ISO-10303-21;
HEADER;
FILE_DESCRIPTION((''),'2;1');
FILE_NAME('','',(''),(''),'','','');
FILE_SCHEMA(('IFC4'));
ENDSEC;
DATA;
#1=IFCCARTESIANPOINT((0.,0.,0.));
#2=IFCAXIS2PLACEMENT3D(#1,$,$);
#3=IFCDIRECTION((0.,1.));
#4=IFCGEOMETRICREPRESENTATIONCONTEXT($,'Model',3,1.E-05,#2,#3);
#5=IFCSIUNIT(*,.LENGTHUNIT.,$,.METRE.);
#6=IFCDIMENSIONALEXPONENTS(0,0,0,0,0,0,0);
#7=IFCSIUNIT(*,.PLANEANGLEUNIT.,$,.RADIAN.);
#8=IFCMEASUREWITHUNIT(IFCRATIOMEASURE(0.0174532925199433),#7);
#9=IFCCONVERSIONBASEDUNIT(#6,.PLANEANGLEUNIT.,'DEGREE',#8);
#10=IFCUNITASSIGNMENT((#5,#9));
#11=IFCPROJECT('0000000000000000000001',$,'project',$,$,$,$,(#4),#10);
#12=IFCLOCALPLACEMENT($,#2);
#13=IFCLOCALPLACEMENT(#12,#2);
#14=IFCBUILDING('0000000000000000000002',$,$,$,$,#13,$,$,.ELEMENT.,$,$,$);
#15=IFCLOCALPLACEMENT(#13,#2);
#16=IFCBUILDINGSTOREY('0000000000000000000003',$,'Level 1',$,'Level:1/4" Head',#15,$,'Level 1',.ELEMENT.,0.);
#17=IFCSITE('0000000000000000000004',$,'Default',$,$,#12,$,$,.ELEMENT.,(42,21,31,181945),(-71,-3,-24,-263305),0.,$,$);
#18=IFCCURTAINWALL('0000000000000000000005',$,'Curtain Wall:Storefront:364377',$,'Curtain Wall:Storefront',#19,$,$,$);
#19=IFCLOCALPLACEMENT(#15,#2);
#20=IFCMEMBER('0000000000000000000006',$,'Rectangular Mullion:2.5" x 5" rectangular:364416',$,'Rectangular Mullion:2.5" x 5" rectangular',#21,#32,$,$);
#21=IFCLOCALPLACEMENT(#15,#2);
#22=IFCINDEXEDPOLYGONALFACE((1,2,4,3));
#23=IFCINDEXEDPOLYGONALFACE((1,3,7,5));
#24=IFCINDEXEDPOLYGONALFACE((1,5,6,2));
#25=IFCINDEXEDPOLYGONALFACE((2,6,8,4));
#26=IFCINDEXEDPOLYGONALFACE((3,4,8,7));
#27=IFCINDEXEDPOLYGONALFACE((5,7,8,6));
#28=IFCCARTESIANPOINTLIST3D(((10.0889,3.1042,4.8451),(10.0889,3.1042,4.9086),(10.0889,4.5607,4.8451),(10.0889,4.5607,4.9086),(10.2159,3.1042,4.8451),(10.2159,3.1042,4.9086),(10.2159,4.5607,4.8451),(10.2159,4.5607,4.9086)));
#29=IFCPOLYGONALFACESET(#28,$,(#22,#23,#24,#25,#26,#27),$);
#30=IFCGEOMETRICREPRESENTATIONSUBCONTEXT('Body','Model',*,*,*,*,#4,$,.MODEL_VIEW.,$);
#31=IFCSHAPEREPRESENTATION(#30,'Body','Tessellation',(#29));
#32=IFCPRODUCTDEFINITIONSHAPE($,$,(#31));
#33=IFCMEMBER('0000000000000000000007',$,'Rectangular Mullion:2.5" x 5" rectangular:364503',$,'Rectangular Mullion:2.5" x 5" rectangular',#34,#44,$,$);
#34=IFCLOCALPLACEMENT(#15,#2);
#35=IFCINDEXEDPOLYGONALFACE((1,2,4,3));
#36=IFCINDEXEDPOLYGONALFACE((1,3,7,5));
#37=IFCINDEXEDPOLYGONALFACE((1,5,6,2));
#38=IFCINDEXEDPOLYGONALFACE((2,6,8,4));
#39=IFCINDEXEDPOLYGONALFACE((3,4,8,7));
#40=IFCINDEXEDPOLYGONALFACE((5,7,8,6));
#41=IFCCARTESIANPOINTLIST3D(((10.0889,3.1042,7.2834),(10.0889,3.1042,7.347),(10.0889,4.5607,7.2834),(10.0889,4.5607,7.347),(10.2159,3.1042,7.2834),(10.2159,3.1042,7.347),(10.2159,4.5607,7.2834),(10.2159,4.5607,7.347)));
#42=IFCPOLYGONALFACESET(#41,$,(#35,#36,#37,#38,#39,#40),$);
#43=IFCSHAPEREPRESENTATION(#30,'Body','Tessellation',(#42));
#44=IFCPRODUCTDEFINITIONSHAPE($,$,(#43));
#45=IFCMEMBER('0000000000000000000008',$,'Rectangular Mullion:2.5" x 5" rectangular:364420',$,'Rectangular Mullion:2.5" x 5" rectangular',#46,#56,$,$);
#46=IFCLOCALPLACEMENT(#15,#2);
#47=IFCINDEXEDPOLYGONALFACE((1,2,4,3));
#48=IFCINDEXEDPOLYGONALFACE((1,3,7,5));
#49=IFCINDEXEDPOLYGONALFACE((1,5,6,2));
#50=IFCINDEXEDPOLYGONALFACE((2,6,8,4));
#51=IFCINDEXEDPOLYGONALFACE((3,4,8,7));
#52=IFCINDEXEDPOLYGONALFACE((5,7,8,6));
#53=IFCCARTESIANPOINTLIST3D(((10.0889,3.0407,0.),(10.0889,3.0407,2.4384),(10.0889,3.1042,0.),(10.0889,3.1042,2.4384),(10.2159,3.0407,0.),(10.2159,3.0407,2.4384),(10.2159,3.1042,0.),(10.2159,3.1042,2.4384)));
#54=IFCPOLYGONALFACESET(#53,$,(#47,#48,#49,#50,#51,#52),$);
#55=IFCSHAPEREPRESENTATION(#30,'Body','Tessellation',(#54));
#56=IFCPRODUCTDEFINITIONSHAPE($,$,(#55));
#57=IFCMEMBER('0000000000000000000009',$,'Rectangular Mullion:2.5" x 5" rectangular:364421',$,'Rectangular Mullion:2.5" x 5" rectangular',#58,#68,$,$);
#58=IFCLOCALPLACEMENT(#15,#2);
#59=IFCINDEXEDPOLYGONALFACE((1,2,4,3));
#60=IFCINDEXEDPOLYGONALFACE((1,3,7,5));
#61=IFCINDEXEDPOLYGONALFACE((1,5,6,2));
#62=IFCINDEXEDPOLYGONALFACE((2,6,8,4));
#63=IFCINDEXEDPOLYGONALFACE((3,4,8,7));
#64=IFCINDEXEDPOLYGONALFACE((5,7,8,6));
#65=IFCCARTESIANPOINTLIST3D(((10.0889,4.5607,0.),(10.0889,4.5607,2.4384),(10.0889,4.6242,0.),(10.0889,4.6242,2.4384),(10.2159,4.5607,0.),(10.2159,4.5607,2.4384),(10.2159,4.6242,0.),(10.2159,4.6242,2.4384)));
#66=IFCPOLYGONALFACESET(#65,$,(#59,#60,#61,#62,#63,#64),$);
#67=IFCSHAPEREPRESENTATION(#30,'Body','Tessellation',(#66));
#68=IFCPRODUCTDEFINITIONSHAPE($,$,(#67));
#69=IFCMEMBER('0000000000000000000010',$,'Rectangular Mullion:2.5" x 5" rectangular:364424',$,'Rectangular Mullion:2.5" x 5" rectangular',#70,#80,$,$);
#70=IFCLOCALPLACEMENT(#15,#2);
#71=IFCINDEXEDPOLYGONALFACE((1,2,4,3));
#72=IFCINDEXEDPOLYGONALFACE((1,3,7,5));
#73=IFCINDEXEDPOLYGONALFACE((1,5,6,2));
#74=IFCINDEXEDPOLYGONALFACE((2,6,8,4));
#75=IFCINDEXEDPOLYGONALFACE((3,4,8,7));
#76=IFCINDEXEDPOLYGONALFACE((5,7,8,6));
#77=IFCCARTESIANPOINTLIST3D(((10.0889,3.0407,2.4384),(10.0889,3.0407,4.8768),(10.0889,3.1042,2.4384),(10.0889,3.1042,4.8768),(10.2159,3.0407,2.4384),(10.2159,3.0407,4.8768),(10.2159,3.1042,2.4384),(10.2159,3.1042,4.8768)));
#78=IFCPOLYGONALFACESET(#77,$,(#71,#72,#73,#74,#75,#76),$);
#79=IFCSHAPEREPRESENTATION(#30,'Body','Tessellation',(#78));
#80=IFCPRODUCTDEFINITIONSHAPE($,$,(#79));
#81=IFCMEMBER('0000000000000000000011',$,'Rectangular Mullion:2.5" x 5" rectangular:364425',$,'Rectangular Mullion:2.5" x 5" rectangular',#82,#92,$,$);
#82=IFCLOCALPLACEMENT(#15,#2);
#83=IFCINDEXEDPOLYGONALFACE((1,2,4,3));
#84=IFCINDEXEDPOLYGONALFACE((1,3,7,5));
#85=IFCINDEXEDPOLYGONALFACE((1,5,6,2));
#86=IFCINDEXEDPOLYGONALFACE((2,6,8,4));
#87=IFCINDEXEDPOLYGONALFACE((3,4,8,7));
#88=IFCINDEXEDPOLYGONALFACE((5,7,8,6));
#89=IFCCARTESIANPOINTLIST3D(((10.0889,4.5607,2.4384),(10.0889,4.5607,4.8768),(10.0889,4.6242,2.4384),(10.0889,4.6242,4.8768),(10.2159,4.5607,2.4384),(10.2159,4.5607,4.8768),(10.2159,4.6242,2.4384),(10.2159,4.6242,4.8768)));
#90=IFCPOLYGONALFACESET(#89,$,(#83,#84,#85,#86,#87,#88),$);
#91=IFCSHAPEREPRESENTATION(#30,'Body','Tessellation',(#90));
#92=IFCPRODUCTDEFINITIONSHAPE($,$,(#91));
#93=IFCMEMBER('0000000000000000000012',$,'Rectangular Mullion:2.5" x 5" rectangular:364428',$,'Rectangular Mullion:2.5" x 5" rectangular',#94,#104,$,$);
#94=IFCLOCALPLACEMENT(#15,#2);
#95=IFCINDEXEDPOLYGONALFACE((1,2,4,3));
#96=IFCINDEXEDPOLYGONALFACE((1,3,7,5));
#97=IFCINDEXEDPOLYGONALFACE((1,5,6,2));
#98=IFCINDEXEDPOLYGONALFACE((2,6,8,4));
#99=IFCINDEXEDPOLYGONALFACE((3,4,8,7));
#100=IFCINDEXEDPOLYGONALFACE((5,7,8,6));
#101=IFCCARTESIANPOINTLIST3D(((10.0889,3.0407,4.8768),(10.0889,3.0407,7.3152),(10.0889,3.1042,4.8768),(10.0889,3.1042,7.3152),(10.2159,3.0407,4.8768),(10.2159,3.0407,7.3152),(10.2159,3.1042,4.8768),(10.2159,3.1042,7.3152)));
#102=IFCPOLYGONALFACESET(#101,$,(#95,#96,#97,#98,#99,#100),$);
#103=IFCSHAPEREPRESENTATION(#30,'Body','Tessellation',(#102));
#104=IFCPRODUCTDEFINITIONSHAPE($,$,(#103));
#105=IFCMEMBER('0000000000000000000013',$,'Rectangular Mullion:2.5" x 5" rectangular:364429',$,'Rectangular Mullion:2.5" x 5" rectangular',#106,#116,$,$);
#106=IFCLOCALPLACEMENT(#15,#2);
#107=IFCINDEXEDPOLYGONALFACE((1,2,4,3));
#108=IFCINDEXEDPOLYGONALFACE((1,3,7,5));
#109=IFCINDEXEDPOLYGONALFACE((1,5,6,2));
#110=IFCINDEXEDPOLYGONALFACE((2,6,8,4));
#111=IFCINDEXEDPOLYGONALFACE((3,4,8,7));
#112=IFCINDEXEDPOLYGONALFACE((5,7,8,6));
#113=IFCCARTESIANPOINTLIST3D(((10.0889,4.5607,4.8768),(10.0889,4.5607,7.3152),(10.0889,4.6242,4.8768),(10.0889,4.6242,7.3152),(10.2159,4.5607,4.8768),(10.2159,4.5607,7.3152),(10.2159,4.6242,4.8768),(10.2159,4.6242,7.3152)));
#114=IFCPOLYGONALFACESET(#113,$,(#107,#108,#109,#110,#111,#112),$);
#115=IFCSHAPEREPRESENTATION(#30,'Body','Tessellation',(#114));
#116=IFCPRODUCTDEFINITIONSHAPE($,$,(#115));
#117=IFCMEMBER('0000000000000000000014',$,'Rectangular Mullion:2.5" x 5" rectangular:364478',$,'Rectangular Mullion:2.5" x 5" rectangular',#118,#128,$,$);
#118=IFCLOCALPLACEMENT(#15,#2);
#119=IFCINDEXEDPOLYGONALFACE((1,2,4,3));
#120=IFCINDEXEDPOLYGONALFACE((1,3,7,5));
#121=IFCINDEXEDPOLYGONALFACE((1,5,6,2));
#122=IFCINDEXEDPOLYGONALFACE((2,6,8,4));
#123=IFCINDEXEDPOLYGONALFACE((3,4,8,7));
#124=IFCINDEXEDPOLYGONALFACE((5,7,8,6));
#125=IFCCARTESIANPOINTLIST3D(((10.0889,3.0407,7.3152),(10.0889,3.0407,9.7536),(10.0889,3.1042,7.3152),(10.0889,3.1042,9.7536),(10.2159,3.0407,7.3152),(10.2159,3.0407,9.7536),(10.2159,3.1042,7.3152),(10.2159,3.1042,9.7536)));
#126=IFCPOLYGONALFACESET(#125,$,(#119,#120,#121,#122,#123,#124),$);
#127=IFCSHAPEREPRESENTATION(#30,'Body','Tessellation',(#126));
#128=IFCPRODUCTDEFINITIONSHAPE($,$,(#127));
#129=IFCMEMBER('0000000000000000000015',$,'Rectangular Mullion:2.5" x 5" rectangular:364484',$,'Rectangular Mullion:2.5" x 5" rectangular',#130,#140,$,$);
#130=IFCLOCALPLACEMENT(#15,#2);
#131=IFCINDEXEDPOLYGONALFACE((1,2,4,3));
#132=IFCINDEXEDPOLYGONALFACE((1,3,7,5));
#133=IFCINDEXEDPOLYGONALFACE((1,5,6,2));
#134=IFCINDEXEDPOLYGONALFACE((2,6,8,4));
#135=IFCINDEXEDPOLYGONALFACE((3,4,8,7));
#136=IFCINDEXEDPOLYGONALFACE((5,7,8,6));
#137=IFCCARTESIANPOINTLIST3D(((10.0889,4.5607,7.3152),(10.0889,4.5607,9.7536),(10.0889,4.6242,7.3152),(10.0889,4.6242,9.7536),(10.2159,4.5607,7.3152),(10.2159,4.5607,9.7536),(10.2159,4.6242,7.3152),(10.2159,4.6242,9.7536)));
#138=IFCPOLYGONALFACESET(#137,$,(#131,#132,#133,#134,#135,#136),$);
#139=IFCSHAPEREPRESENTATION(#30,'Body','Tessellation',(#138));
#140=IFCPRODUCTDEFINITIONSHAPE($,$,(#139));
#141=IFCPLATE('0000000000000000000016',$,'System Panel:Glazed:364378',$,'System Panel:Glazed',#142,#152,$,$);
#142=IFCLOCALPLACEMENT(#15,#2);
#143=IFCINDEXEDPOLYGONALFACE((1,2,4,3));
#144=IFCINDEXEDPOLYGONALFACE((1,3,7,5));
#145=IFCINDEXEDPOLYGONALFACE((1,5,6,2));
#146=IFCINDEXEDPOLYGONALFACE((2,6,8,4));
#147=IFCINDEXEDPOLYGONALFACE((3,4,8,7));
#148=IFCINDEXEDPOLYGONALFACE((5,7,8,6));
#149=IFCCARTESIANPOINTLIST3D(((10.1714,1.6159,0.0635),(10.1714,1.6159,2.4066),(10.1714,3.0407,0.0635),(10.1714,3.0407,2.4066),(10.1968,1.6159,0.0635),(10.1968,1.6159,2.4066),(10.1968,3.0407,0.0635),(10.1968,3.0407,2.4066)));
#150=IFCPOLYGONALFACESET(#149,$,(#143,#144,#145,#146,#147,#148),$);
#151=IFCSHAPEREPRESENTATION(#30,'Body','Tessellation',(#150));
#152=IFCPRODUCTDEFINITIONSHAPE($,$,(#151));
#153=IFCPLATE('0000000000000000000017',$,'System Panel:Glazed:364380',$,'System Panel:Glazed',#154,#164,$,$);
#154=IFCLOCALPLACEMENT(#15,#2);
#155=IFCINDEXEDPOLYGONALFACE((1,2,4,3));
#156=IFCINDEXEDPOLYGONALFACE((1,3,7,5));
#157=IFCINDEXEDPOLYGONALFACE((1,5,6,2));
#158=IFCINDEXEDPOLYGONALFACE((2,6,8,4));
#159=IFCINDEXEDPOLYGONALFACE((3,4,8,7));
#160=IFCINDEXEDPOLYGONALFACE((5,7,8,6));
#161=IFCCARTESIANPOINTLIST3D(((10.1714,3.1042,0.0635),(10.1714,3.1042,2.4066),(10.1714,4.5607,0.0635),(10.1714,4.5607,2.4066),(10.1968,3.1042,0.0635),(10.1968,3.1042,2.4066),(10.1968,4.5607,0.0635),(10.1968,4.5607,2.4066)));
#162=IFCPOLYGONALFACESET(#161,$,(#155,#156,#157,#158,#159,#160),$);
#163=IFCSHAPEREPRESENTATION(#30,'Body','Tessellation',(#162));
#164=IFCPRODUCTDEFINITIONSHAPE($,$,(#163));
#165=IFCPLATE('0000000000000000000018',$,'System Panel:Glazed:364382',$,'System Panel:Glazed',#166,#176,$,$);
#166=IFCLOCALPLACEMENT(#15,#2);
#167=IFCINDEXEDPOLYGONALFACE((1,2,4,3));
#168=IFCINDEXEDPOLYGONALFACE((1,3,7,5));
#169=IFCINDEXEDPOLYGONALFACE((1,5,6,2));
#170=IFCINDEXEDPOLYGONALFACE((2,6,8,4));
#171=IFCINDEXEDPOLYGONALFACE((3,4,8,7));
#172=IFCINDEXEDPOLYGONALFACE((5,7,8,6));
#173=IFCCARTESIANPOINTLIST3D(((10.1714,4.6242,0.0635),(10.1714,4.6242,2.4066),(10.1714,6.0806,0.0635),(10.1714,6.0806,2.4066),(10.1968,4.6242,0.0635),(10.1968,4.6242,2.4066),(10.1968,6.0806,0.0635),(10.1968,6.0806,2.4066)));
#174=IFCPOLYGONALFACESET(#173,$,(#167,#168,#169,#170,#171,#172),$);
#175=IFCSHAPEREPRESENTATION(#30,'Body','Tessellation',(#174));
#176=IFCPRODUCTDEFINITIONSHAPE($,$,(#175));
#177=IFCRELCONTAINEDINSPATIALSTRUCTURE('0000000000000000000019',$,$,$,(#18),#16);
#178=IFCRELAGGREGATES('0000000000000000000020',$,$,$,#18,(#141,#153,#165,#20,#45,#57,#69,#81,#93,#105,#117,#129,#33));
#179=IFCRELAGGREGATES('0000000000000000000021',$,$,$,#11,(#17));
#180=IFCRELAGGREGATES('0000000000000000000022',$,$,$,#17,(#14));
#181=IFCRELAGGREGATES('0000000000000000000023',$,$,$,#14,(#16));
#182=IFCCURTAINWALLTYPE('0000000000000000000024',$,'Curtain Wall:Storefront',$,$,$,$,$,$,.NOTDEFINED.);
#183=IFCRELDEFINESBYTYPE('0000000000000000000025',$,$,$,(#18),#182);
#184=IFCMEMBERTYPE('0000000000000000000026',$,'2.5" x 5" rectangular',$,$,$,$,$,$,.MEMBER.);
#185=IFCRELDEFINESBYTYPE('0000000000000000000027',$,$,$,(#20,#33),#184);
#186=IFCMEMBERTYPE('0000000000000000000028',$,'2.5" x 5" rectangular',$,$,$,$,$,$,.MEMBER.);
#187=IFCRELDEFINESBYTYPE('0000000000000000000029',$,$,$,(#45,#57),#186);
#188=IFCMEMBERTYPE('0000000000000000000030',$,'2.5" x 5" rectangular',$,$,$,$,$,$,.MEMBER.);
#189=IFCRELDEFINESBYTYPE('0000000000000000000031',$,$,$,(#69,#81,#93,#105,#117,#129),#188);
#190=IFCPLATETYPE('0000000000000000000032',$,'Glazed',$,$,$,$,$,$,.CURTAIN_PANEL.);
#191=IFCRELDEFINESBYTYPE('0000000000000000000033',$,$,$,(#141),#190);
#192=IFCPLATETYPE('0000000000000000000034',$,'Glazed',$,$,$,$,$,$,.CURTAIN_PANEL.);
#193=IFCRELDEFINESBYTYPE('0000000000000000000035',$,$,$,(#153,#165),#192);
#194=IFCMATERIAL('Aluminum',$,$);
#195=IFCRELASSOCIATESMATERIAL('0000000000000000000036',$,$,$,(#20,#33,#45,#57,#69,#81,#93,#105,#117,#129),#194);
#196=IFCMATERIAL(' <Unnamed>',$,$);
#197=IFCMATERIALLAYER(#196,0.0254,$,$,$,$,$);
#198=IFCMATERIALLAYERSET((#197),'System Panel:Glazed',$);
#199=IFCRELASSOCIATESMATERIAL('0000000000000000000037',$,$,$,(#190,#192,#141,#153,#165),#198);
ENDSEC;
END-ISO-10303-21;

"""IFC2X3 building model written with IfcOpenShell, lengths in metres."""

from ifc_helpers import new_model, entity, si_unit, converted_unit, direction, frame, frame_2d, origin, origin_2d_with_axis, place, context, subcontext, project, spatial, rectangle, extrude, source, transform, mapped, material, layer, layer_set, layer_usage, type_object, type_shapes, element, aggregate, save


model = new_model("IFC2X3")

# Units and contexts
model_context = context("Model", 3, precision=1e-05, world=origin(), true_north=direction((0.0, 1.0)))
body_context = subcontext(model_context, "Body", "Model", "MODEL_VIEW")
ifc_project = project(units=[si_unit("LENGTHUNIT", "METRE"), converted_unit("PLANEANGLEUNIT", "DEGREE", entity("IfcRatioMeasure", 0.0174532925199433), si_unit("PLANEANGLEUNIT", "RADIAN"), dimensions=[0, 0, 0, 0, 0, 0, 0])], contexts=[model_context])

# Site, building, storey
site_placement = place(None, origin())
site = spatial("IfcSite", under=ifc_project, at=site_placement, Name="Default", CompositionType="ELEMENT", RefLatitude=(42, 21, 31, 181945), RefLongitude=(-71, -3, -24, -263305), RefElevation=0.0)
building_placement = place(site_placement, origin())
building = spatial("IfcBuilding", under=site, at=building_placement, CompositionType="ELEMENT")
storey_placement = place(building_placement, origin())
storey = spatial("IfcBuildingStorey", under=building, at=storey_placement, Name="Level 1", ObjectType="Level:1/4\" Head", LongName="Level 1", CompositionType="ELEMENT", Elevation=0.0)

# Shared definitions
curtain_wall_type = type_object("IfcCurtainWallType", Name="Curtain Wall:Storefront", PredefinedType="NOTDEFINED")
ifc_material_1 = material(Name="Aluminum")

# Curtain wall, members, plates
curtain_wall_1_placement = place(storey_placement, origin())
curtain_wall_1 = element("IfcCurtainWall", 1, at=curtain_wall_1_placement, inside=storey, type_object=curtain_wall_type, Name="Curtain Wall:Storefront:364377", ObjectType="Curtain Wall:Storefront")
member_type_1 = type_object("IfcMemberType", Name="2.5\" x 5\" rectangular", PredefinedType="MEMBER")
shared_shape_1 = source(origin(), body_context, "Body", "SweptSolid", [
    extrude(rectangle(XDim=0.127, YDim=0.0635, at=origin_2d_with_axis()), frame((0.0, 0.0, -1.4565), z_axis=(0.0, 0.0, 1.0), x_axis=(0.0, -1.0, 0.0)), (0.0, 0.0, 1.0), 1.4565),
])
type_shapes(member_type_1, [shared_shape_1])
member_1_placement = place(storey_placement, frame((10.1524, 4.5607, 4.8768), z_axis=(0.0, 1.0, 0.0), x_axis=(0.0, 0.0, 1.0)))
member_1 = element("IfcMember", 2, at=member_1_placement, type_object=member_type_1, material=ifc_material_1, Name="Rectangular Mullion:2.5\" x 5\" rectangular:364416", ObjectType="Rectangular Mullion:2.5\" x 5\" rectangular", context=body_context, shape_type="MappedRepresentation", body=[
    mapped(shared_shape_1, transform((0.0, 0.0, 0.0), scale=1.0)),
])
member_2_placement = place(storey_placement, frame((10.1524, 4.5607, 7.3152), z_axis=(0.0, 1.0, 0.0), x_axis=(0.0, 0.0, 1.0)))
member_2 = element("IfcMember", 3, at=member_2_placement, type_object=member_type_1, material=ifc_material_1, Name="Rectangular Mullion:2.5\" x 5\" rectangular:364503", ObjectType="Rectangular Mullion:2.5\" x 5\" rectangular", context=body_context, shape_type="MappedRepresentation", body=[
    mapped(shared_shape_1, transform((0.0, 0.0, 0.0), scale=1.0)),
])
member_type_2 = type_object("IfcMemberType", Name="2.5\" x 5\" rectangular", PredefinedType="MEMBER")
shared_shape_2 = source(origin(), body_context, "Body", "SweptSolid", [
    extrude(rectangle(XDim=0.127, YDim=0.0635, at=origin_2d_with_axis()), frame((0.0, 0.0, -2.4384), z_axis=(0.0, 0.0, 1.0), x_axis=(0.0, -1.0, 0.0)), (0.0, 0.0, 1.0), 2.4384),
])
type_shapes(member_type_2, [shared_shape_2])
member_3_placement = place(storey_placement, frame((10.1524, 3.0724, 0.0), z_axis=(0.0, 0.0, -1.0), x_axis=(0.0, 1.0, 0.0)))
member_3 = element("IfcMember", 4, at=member_3_placement, type_object=member_type_2, material=ifc_material_1, Name="Rectangular Mullion:2.5\" x 5\" rectangular:364420", ObjectType="Rectangular Mullion:2.5\" x 5\" rectangular", context=body_context, shape_type="MappedRepresentation", body=[
    mapped(shared_shape_2, transform((0.0, 0.0, 0.0), scale=1.0)),
])
member_4_placement = place(storey_placement, frame((10.1524, 4.5924, 0.0), z_axis=(0.0, 0.0, -1.0), x_axis=(0.0, 1.0, 0.0)))
member_4 = element("IfcMember", 5, at=member_4_placement, type_object=member_type_2, material=ifc_material_1, Name="Rectangular Mullion:2.5\" x 5\" rectangular:364421", ObjectType="Rectangular Mullion:2.5\" x 5\" rectangular", context=body_context, shape_type="MappedRepresentation", body=[
    mapped(shared_shape_2, transform((0.0, 0.0, 0.0), scale=1.0)),
])
member_type_3 = type_object("IfcMemberType", Name="2.5\" x 5\" rectangular", PredefinedType="MEMBER")
shared_shape_3 = source(origin(), body_context, "Body", "SweptSolid", [
    extrude(rectangle(XDim=0.127, YDim=0.0635, at=origin_2d_with_axis()), frame((0.0, 0.0, -2.4384), z_axis=(0.0, 0.0, 1.0), x_axis=(0.0, -1.0, 0.0)), (0.0, 0.0, 1.0), 2.4384),
])
type_shapes(member_type_3, [shared_shape_3])
member_5_placement = place(storey_placement, frame((10.1524, 3.0724, 2.4384), z_axis=(0.0, 0.0, -1.0), x_axis=(0.0, 1.0, 0.0)))
member_5 = element("IfcMember", 6, at=member_5_placement, type_object=member_type_3, material=ifc_material_1, Name="Rectangular Mullion:2.5\" x 5\" rectangular:364424", ObjectType="Rectangular Mullion:2.5\" x 5\" rectangular", context=body_context, shape_type="MappedRepresentation", body=[
    mapped(shared_shape_3, transform((0.0, 0.0, 0.0), scale=1.0)),
])
member_6_placement = place(storey_placement, frame((10.1524, 4.5924, 2.4384), z_axis=(0.0, 0.0, -1.0), x_axis=(0.0, 1.0, 0.0)))
member_6 = element("IfcMember", 7, at=member_6_placement, type_object=member_type_3, material=ifc_material_1, Name="Rectangular Mullion:2.5\" x 5\" rectangular:364425", ObjectType="Rectangular Mullion:2.5\" x 5\" rectangular", context=body_context, shape_type="MappedRepresentation", body=[
    mapped(shared_shape_3, transform((0.0, 0.0, 0.0), scale=1.0)),
])
member_7_placement = place(storey_placement, frame((10.1524, 3.0724, 4.8768), z_axis=(0.0, 0.0, -1.0), x_axis=(0.0, 1.0, 0.0)))
member_7 = element("IfcMember", 8, at=member_7_placement, type_object=member_type_3, material=ifc_material_1, Name="Rectangular Mullion:2.5\" x 5\" rectangular:364428", ObjectType="Rectangular Mullion:2.5\" x 5\" rectangular", context=body_context, shape_type="MappedRepresentation", body=[
    mapped(shared_shape_3, transform((0.0, 0.0, 0.0), scale=1.0)),
])
member_8_placement = place(storey_placement, frame((10.1524, 4.5924, 4.8768), z_axis=(0.0, 0.0, -1.0), x_axis=(0.0, 1.0, 0.0)))
member_8 = element("IfcMember", 9, at=member_8_placement, type_object=member_type_3, material=ifc_material_1, Name="Rectangular Mullion:2.5\" x 5\" rectangular:364429", ObjectType="Rectangular Mullion:2.5\" x 5\" rectangular", context=body_context, shape_type="MappedRepresentation", body=[
    mapped(shared_shape_3, transform((0.0, 0.0, 0.0), scale=1.0)),
])
member_9_placement = place(storey_placement, frame((10.1524, 3.0724, 7.3152), z_axis=(0.0, 0.0, -1.0), x_axis=(0.0, 1.0, 0.0)))
member_9 = element("IfcMember", 10, at=member_9_placement, type_object=member_type_3, material=ifc_material_1, Name="Rectangular Mullion:2.5\" x 5\" rectangular:364478", ObjectType="Rectangular Mullion:2.5\" x 5\" rectangular", context=body_context, shape_type="MappedRepresentation", body=[
    mapped(shared_shape_3, transform((0.0, 0.0, 0.0), scale=1.0)),
])
member_10_placement = place(storey_placement, frame((10.1524, 4.5924, 7.3152), z_axis=(0.0, 0.0, -1.0), x_axis=(0.0, 1.0, 0.0)))
member_10 = element("IfcMember", 11, at=member_10_placement, type_object=member_type_3, material=ifc_material_1, Name="Rectangular Mullion:2.5\" x 5\" rectangular:364484", ObjectType="Rectangular Mullion:2.5\" x 5\" rectangular", context=body_context, shape_type="MappedRepresentation", body=[
    mapped(shared_shape_3, transform((0.0, 0.0, 0.0), scale=1.0)),
])
ifc_material_2 = material(Name=" <Unnamed>")
ifc_layer_1 = layer(ifc_material_2, 0.0254)
ifc_layer_set_1 = layer_set([ifc_layer_1], Name="System Panel:Glazed")
ifc_layer_usage_1 = layer_usage(ifc_layer_set_1, "AXIS3", "POSITIVE", 0.1042)
plate_type_1 = type_object("IfcPlateType", Name="Glazed", PredefinedType="CURTAIN_PANEL", material=ifc_layer_set_1)
shared_shape_4 = source(origin(), body_context, "Body", "SweptSolid", [
    extrude(rectangle(XDim=0.0254, YDim=1.4248, at=frame_2d((0.0, 0.0), x_axis=(1.0, 0.0))), frame((0.7124, 0.0127, 0.0), z_axis=(0.0, 0.0, 1.0), x_axis=(0.0, 1.0, 0.0)), (0.0, 0.0, 1.0), 2.3432),
])
type_shapes(plate_type_1, [shared_shape_4])
plate_1_placement = place(curtain_wall_1_placement, frame((10.1968, 1.6159, 0.0635), z_axis=(0.0, 0.0, 1.0), x_axis=(0.0, 1.0, 0.0)))
plate_1 = element("IfcPlate", 12, at=plate_1_placement, type_object=plate_type_1, material=ifc_layer_usage_1, Name="System Panel:Glazed:364378", ObjectType="System Panel:Glazed", context=body_context, shape_type="MappedRepresentation", body=[
    mapped(shared_shape_4, transform((0.0, 0.0, 0.0), scale=1.0)),
])
ifc_layer_usage_2 = layer_usage(ifc_layer_set_1, "AXIS3", "POSITIVE", 0.1042)
plate_type_2 = type_object("IfcPlateType", Name="Glazed", PredefinedType="CURTAIN_PANEL", material=ifc_layer_set_1)
shared_shape_5 = source(origin(), body_context, "Body", "SweptSolid", [
    extrude(rectangle(XDim=0.0254, YDim=1.4565, at=origin_2d_with_axis()), frame((0.7282, 0.0127, 0.0), z_axis=(0.0, 0.0, 1.0), x_axis=(0.0, 1.0, 0.0)), (0.0, 0.0, 1.0), 2.3432),
])
type_shapes(plate_type_2, [shared_shape_5])
plate_2_placement = place(curtain_wall_1_placement, frame((10.1968, 3.1042, 0.0635), z_axis=(0.0, 0.0, 1.0), x_axis=(0.0, 1.0, 0.0)))
plate_2 = element("IfcPlate", 13, at=plate_2_placement, type_object=plate_type_2, material=ifc_layer_usage_2, Name="System Panel:Glazed:364380", ObjectType="System Panel:Glazed", context=body_context, shape_type="MappedRepresentation", body=[
    mapped(shared_shape_5, transform((0.0, 0.0, 0.0), scale=1.0)),
])
ifc_layer_usage_3 = layer_usage(ifc_layer_set_1, "AXIS3", "POSITIVE", 0.1042)
plate_3_placement = place(curtain_wall_1_placement, frame((10.1968, 4.6242, 0.0635), z_axis=(0.0, 0.0, 1.0), x_axis=(0.0, 1.0, 0.0)))
plate_3 = element("IfcPlate", 14, at=plate_3_placement, type_object=plate_type_2, material=ifc_layer_usage_3, Name="System Panel:Glazed:364382", ObjectType="System Panel:Glazed", context=body_context, shape_type="MappedRepresentation", body=[
    mapped(shared_shape_5, transform((0.0, 0.0, 0.0), scale=1.0)),
])
aggregate(curtain_wall_1, [plate_1, plate_2, plate_3, member_1, member_3, member_4, member_5, member_6, member_7, member_8, member_9, member_10, member_2])

save(model, "model.ifc")
